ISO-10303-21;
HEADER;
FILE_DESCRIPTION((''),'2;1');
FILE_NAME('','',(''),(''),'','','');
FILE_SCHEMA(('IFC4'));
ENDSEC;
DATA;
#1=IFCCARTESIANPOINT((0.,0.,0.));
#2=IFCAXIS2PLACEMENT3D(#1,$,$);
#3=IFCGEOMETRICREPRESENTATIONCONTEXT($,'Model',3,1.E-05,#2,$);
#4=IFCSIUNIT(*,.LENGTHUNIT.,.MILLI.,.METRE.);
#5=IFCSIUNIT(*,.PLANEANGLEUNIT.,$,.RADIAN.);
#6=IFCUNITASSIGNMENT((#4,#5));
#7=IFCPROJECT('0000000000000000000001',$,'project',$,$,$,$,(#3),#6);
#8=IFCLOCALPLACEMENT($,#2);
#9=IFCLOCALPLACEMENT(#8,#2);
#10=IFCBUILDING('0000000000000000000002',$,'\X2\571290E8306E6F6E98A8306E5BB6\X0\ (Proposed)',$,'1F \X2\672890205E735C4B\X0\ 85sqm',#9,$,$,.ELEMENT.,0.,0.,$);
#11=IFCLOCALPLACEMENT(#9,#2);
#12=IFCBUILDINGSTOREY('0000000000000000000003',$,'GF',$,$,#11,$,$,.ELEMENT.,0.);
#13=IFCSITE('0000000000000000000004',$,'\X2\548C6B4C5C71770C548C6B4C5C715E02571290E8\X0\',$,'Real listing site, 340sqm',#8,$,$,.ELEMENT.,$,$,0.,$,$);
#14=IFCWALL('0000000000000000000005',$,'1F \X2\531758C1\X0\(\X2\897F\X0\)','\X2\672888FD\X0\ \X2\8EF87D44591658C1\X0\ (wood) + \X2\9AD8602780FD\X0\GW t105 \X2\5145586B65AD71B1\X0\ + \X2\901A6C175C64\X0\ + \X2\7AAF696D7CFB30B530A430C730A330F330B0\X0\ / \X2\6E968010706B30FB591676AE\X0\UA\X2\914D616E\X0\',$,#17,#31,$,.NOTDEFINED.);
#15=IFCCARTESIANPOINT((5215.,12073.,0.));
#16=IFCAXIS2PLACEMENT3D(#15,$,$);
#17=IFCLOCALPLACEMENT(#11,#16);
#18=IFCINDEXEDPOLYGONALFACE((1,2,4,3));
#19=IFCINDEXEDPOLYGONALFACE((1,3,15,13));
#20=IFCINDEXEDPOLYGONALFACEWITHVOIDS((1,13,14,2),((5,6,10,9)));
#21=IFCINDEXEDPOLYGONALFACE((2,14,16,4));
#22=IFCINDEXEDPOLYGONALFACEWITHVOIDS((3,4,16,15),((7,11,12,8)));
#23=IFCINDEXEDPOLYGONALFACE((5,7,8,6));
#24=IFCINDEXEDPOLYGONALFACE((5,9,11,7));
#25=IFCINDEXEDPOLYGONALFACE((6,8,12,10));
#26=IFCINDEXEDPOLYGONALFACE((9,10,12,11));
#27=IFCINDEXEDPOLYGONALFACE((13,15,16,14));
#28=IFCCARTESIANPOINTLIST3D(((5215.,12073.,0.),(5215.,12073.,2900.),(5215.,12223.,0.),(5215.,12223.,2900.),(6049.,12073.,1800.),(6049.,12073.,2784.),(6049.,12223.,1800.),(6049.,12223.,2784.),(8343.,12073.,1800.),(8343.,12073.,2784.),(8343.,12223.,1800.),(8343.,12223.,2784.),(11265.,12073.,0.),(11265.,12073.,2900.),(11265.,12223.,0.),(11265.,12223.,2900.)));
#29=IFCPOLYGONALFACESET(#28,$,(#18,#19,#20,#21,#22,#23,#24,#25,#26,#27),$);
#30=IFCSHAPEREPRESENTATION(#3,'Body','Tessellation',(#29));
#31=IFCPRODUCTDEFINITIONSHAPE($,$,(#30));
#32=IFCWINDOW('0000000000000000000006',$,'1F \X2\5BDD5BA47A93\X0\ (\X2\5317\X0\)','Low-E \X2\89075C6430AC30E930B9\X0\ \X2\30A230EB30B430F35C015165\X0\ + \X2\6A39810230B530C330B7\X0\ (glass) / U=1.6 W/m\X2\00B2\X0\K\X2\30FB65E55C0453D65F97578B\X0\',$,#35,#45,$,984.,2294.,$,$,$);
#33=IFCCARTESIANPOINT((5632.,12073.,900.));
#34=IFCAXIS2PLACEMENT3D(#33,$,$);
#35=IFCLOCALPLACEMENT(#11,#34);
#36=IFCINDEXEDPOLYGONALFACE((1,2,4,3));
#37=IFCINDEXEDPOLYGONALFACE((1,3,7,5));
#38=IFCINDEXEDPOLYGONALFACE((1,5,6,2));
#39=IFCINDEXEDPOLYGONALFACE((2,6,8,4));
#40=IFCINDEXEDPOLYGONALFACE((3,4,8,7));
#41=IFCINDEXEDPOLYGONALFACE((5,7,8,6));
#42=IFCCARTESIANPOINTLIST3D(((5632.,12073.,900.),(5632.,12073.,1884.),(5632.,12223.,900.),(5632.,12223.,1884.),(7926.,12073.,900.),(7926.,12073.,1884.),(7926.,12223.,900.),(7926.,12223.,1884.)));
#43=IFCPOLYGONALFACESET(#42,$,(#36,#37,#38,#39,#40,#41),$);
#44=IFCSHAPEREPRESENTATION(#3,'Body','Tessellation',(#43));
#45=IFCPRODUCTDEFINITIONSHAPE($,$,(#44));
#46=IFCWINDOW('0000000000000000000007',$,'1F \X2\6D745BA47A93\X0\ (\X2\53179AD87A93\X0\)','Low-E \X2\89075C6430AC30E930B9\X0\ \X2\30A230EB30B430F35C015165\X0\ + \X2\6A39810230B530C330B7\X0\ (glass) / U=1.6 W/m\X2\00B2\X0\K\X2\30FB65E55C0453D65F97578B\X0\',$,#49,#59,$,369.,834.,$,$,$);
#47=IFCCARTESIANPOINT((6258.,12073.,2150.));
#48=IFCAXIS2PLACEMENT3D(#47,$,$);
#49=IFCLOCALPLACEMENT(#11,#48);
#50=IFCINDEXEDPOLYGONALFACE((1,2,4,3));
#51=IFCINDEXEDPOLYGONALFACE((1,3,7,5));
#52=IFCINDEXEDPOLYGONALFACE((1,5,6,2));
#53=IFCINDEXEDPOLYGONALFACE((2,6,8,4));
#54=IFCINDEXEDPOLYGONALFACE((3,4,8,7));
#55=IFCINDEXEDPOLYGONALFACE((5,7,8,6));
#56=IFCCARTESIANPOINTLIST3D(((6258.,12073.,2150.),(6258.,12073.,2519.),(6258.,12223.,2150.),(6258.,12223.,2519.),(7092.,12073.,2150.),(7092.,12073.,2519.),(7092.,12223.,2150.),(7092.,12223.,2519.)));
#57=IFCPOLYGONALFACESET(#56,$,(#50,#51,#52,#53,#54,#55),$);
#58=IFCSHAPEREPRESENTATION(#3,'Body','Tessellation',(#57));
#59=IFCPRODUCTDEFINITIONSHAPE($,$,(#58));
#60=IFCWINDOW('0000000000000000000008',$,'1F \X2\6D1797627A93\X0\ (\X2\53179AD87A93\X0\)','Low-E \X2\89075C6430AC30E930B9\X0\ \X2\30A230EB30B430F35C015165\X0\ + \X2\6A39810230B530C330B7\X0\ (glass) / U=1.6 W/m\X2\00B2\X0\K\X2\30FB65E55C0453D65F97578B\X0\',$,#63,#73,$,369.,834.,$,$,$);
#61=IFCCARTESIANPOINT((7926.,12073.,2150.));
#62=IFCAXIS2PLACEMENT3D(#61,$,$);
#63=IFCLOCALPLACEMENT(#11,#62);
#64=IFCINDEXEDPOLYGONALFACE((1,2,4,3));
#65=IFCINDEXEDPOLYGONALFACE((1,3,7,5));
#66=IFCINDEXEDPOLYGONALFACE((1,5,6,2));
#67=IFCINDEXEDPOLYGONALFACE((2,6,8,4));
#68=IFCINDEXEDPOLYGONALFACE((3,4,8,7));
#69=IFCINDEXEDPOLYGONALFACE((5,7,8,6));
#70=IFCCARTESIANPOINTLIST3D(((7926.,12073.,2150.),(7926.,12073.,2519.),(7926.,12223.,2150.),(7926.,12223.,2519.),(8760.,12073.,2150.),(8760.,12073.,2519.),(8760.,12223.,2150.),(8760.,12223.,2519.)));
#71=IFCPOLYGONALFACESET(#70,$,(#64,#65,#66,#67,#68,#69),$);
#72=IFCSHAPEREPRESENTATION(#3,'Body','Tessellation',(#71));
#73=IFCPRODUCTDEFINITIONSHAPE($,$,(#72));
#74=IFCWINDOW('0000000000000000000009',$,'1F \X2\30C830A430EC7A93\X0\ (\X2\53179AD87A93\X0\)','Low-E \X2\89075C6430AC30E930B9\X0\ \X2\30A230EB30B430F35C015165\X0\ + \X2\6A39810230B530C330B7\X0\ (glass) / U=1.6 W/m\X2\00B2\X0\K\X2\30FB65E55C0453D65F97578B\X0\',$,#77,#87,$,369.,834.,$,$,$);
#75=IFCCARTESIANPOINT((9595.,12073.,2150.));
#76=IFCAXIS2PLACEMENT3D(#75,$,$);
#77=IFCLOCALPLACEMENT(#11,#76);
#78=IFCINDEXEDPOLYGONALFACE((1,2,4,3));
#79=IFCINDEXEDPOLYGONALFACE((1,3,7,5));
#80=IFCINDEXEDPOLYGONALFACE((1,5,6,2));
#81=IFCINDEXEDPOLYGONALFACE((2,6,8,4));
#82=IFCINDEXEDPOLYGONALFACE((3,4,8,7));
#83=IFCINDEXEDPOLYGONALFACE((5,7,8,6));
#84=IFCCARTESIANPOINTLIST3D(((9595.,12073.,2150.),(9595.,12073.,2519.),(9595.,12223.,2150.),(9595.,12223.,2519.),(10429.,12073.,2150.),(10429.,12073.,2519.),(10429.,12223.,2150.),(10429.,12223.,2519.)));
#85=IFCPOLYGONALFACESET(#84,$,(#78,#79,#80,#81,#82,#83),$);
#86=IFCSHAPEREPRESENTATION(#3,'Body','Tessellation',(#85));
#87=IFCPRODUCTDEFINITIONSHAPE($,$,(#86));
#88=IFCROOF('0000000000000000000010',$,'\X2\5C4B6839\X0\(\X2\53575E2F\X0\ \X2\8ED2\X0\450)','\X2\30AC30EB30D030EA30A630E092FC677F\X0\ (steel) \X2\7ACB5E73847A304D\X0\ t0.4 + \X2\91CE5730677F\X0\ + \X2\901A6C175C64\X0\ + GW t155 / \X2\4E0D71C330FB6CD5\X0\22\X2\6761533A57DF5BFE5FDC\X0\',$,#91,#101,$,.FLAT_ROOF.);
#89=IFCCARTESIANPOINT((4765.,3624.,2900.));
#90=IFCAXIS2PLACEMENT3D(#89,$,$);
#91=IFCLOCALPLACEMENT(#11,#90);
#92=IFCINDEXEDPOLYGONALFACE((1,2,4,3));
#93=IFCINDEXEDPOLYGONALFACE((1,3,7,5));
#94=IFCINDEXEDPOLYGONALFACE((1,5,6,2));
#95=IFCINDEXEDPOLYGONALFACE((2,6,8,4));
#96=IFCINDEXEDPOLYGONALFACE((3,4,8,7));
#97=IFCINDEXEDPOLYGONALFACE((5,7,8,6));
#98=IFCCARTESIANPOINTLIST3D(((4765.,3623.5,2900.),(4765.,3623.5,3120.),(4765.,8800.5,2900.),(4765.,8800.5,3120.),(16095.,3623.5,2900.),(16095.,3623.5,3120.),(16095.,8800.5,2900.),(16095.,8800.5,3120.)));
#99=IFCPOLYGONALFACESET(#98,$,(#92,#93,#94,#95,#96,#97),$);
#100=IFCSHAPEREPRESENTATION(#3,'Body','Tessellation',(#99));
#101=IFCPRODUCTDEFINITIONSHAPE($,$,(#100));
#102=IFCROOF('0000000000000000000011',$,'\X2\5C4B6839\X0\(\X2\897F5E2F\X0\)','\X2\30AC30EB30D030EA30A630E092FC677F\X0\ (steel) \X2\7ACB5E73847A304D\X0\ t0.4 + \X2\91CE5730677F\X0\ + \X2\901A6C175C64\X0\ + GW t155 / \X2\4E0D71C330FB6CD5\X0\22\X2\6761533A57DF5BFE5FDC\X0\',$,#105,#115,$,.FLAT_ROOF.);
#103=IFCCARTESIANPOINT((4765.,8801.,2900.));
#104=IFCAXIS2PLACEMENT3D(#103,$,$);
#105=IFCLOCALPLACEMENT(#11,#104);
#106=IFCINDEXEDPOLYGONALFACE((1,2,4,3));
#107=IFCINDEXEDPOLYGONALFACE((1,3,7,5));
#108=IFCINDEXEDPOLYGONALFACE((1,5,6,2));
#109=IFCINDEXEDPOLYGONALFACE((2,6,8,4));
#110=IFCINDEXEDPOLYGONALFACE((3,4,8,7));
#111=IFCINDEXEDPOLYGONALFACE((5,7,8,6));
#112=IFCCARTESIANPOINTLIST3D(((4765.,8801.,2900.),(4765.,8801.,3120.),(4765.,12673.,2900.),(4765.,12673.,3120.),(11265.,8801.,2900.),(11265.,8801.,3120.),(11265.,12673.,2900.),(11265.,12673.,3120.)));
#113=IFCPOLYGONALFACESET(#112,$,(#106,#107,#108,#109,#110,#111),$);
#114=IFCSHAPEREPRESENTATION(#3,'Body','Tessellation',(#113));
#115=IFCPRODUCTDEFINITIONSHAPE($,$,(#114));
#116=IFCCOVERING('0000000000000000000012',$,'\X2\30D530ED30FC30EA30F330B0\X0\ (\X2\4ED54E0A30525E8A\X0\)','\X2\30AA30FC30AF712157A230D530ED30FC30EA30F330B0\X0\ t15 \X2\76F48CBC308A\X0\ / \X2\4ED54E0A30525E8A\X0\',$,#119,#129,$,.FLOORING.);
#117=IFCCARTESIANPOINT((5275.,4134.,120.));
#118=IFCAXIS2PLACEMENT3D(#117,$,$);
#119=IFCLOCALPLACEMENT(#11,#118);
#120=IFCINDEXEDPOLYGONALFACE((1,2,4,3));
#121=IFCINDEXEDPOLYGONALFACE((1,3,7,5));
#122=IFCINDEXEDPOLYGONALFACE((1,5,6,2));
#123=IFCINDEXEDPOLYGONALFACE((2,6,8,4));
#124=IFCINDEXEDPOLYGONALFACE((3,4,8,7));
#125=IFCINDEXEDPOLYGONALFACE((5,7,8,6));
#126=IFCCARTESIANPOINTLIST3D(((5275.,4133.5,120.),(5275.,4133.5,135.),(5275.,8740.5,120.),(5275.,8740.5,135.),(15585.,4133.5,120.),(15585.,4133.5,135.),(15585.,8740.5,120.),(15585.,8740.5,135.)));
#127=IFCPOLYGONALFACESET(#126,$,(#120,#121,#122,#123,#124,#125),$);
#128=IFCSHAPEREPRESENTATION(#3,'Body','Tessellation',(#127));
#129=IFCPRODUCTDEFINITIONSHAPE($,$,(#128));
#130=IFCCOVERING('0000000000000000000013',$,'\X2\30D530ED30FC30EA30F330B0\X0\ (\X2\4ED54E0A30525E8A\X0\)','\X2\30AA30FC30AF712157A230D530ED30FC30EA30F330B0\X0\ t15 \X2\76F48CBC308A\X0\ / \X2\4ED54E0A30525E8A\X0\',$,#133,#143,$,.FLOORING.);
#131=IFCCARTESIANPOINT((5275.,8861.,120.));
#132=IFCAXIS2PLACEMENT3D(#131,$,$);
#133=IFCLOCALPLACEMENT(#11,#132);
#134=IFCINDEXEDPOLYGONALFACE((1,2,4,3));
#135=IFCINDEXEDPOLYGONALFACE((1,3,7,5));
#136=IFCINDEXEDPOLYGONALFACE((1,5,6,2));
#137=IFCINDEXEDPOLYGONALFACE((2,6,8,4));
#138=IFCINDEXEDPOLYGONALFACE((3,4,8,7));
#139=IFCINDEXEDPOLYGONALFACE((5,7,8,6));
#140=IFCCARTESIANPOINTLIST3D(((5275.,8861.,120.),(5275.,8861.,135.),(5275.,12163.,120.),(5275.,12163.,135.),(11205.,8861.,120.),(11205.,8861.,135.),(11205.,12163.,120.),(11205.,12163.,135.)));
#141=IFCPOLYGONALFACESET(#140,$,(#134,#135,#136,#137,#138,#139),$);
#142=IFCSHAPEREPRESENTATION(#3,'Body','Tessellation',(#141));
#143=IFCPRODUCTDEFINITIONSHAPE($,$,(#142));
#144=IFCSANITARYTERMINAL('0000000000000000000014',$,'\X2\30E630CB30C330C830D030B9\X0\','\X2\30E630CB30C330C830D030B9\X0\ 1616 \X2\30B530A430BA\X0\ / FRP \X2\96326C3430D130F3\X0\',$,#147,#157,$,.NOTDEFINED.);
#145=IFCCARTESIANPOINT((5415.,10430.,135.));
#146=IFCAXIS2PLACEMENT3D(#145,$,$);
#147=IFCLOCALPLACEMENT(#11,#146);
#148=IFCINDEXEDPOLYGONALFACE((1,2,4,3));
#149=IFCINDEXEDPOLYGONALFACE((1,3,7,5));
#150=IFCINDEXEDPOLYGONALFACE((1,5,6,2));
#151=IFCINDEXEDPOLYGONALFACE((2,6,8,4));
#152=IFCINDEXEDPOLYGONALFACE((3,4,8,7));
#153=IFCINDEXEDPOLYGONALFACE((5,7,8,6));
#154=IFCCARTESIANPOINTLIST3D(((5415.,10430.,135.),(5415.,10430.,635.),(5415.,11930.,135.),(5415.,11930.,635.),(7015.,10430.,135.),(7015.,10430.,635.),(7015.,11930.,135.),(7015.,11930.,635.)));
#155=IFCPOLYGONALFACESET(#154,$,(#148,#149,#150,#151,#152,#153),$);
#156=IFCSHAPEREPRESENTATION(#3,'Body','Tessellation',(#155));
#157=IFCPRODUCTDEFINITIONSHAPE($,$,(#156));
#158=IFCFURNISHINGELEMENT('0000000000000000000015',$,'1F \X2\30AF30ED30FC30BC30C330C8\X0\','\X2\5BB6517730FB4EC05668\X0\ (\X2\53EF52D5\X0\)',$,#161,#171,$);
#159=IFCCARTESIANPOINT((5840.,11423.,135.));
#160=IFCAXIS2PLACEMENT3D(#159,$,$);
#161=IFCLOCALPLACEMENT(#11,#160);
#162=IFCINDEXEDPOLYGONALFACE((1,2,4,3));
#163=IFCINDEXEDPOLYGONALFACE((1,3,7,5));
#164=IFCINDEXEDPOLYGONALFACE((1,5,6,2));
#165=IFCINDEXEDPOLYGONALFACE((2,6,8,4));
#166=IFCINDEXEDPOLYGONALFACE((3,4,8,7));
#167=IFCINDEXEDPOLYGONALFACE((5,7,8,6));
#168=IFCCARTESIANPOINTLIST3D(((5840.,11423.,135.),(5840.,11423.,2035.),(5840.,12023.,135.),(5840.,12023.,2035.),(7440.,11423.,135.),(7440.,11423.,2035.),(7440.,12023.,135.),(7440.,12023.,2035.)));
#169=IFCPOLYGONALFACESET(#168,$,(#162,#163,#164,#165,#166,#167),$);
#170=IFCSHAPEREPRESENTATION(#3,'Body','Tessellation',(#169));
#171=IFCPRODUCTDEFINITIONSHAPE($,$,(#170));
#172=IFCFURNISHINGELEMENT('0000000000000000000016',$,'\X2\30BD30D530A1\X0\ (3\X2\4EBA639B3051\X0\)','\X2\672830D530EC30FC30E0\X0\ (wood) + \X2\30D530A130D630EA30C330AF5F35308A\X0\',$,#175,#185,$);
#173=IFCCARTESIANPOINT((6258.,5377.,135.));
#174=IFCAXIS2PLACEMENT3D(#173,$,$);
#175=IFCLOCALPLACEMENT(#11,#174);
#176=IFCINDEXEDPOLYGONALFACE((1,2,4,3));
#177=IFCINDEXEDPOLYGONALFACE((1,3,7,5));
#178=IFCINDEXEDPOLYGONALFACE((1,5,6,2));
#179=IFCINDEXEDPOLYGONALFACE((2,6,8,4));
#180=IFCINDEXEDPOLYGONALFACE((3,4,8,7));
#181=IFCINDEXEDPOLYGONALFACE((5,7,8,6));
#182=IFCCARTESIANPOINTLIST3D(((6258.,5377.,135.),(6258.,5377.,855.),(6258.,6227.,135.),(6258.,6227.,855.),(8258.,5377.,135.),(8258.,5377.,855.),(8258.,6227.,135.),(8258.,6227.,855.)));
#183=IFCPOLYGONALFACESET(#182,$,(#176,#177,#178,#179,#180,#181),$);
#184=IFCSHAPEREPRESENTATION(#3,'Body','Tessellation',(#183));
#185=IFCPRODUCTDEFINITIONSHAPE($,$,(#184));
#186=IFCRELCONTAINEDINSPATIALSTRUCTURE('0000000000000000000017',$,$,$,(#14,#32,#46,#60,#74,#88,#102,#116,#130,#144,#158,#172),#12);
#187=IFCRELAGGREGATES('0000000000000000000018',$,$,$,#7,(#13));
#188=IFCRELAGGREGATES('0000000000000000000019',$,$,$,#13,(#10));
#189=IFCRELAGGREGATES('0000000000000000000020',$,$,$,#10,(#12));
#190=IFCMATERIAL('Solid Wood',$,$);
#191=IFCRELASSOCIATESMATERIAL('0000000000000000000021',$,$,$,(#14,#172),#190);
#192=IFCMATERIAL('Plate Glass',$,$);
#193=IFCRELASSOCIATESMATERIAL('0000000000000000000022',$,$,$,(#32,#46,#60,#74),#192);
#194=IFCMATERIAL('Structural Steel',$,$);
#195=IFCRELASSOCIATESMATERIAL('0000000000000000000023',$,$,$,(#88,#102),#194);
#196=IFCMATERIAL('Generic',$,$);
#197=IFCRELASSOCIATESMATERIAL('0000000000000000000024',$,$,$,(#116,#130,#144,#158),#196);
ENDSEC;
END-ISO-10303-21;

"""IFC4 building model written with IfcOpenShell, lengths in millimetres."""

from ifc_helpers import new_model, si_unit, frame, frame_2d, origin, place, context, project, spatial, rectangle, extrude, material, element, fill, save


model = new_model("IFC4")

# Units and contexts
model_context = context("Model", 3, precision=1e-05, world=origin())
ifc_project = project(units=[si_unit("LENGTHUNIT", "METRE", prefix="MILLI"), si_unit("PLANEANGLEUNIT", "RADIAN")], contexts=[model_context])

# Site, building, storey
site_placement = place(None, origin())
site = spatial("IfcSite", under=ifc_project, at=site_placement, Name="和歌山県和歌山市園部", ObjectType="Real listing site, 340sqm", CompositionType="ELEMENT", RefElevation=0.0)
building_placement = place(site_placement, origin())
building = spatial("IfcBuilding", under=site, at=building_placement, Name="園部の潮風の家 (Proposed)", ObjectType="1F 木造平屋 85sqm", CompositionType="ELEMENT", ElevationOfRefHeight=0.0, ElevationOfTerrain=0.0)
storey_placement = place(building_placement, origin())
storey = spatial("IfcBuildingStorey", under=building, at=storey_placement, Name="GF", CompositionType="ELEMENT", Elevation=0.0)

# Shared definitions
ifc_material_1 = material(Name="Solid Wood")

# Shared definitions
ifc_material_2 = material(Name="Plate Glass")

# Wall, openings, windows
wall_1_placement = place(storey_placement, frame((5215.0, 12073.0, 0.0)))
wall_1 = element("IfcWall", 1, at=wall_1_placement, inside=storey, material=ifc_material_1, Name="1F 北壁(西)", Description="木製 軸組外壁 (wood) + 高性能GW t105 充填断熱 + 通気層 + 窯業系サイディング / 準耐火・外皮UA配慮", PredefinedType="NOTDEFINED", context=model_context, shape_type="SweptSolid", body=[
    extrude(rectangle(XDim=6050.0, YDim=150.0, at=frame_2d((3025.0, 75.0))), frame((5215.0, 12073.0, 0.0)), (0.0, 0.0, 1.0), 2900.0),
])
opening_1_placement = place(storey_placement, frame((5632.0, 12073.0, 900.0)))
opening_1 = element("IfcOpeningElement", 2, at=opening_1_placement, cuts=wall_1, PredefinedType="NOTDEFINED", context=model_context, shape_type="SweptSolid", body=[
    extrude(rectangle(XDim=2294.0, YDim=150.0, at=frame_2d((1147.0, 75.0))), frame((5632.0, 12073.0, 900.0)), (0.0, 0.0, 1.0), 984.0),
])
opening_2_placement = place(storey_placement, frame((6258.0, 12073.0, 2150.0)))
opening_2 = element("IfcOpeningElement", 3, at=opening_2_placement, cuts=wall_1, PredefinedType="NOTDEFINED", context=model_context, shape_type="SweptSolid", body=[
    extrude(rectangle(XDim=834.0, YDim=150.0, at=frame_2d((417.0, 75.0))), frame((6258.0, 12073.0, 2150.0)), (0.0, 0.0, 1.0), 369.0),
])
opening_3_placement = place(storey_placement, frame((7926.0, 12073.0, 2150.0)))
opening_3 = element("IfcOpeningElement", 4, at=opening_3_placement, cuts=wall_1, PredefinedType="NOTDEFINED", context=model_context, shape_type="SweptSolid", body=[
    extrude(rectangle(XDim=834.0, YDim=150.0, at=frame_2d((417.0, 75.0))), frame((7926.0, 12073.0, 2150.0)), (0.0, 0.0, 1.0), 369.0),
])
opening_4_placement = place(storey_placement, frame((9595.0, 12073.0, 2150.0)))
opening_4 = element("IfcOpeningElement", 5, at=opening_4_placement, cuts=wall_1, PredefinedType="NOTDEFINED", context=model_context, shape_type="SweptSolid", body=[
    extrude(rectangle(XDim=834.0, YDim=150.0, at=frame_2d((417.0, 75.0))), frame((9595.0, 12073.0, 2150.0)), (0.0, 0.0, 1.0), 369.0),
])
window_1_placement = place(storey_placement, frame((5632.0, 12073.0, 900.0)))
window_1 = element("IfcWindow", 6, at=window_1_placement, inside=storey, material=ifc_material_2, Name="1F 寝室窓 (北)", Description="Low-E 複層ガラス アルゴン封入 + 樹脂サッシ (glass) / U=1.6 W/m²K・日射取得型", OverallHeight=984.0, OverallWidth=2294.0, context=model_context, shape_type="SweptSolid", body=[
    extrude(rectangle(XDim=2294.0, YDim=150.0, at=frame_2d((1147.0, 75.0))), frame((5632.0, 12073.0, 900.0)), (0.0, 0.0, 1.0), 984.0),
])
fill(opening_1, window_1)
window_2_placement = place(storey_placement, frame((6258.0, 12073.0, 2150.0)))
window_2 = element("IfcWindow", 7, at=window_2_placement, inside=storey, material=ifc_material_2, Name="1F 浴室窓 (北高窓)", Description="Low-E 複層ガラス アルゴン封入 + 樹脂サッシ (glass) / U=1.6 W/m²K・日射取得型", OverallHeight=369.0, OverallWidth=834.0, context=model_context, shape_type="SweptSolid", body=[
    extrude(rectangle(XDim=834.0, YDim=150.0, at=frame_2d((417.0, 75.0))), frame((6258.0, 12073.0, 2150.0)), (0.0, 0.0, 1.0), 369.0),
])
fill(opening_2, window_2)
window_3_placement = place(storey_placement, frame((7926.0, 12073.0, 2150.0)))
window_3 = element("IfcWindow", 8, at=window_3_placement, inside=storey, material=ifc_material_2, Name="1F 洗面窓 (北高窓)", Description="Low-E 複層ガラス アルゴン封入 + 樹脂サッシ (glass) / U=1.6 W/m²K・日射取得型", OverallHeight=369.0, OverallWidth=834.0, context=model_context, shape_type="SweptSolid", body=[
    extrude(rectangle(XDim=834.0, YDim=150.0, at=frame_2d((417.0, 75.0))), frame((7926.0, 12073.0, 2150.0)), (0.0, 0.0, 1.0), 369.0),
])
fill(opening_3, window_3)
window_4_placement = place(storey_placement, frame((9595.0, 12073.0, 2150.0)))
window_4 = element("IfcWindow", 9, at=window_4_placement, inside=storey, material=ifc_material_2, Name="1F トイレ窓 (北高窓)", Description="Low-E 複層ガラス アルゴン封入 + 樹脂サッシ (glass) / U=1.6 W/m²K・日射取得型", OverallHeight=369.0, OverallWidth=834.0, context=model_context, shape_type="SweptSolid", body=[
    extrude(rectangle(XDim=834.0, YDim=150.0, at=frame_2d((417.0, 75.0))), frame((9595.0, 12073.0, 2150.0)), (0.0, 0.0, 1.0), 369.0),
])
fill(opening_4, window_4)

# Roofs
ifc_material_3 = material(Name="Structural Steel")
roof_1_placement = place(storey_placement, frame((4765.0, 3624.0, 2900.0)))
element("IfcRoof", 10, at=roof_1_placement, inside=storey, material=ifc_material_3, Name="屋根(南帯 軒450)", Description="ガルバリウム鋼板 (steel) 立平葺き t0.4 + 野地板 + 通気層 + GW t155 / 不燃・法22条区域対応", PredefinedType="FLAT_ROOF", context=model_context, shape_type="SweptSolid", body=[
    extrude(rectangle(XDim=11330.0, YDim=5177.0, at=frame_2d((5665.0, 2588.0))), frame((4765.0, 3624.0, 2900.0)), (0.0, 0.0, 1.0), 220.0),
])
roof_2_placement = place(storey_placement, frame((4765.0, 8801.0, 2900.0)))
element("IfcRoof", 11, at=roof_2_placement, inside=storey, material=ifc_material_3, Name="屋根(西帯)", Description="ガルバリウム鋼板 (steel) 立平葺き t0.4 + 野地板 + 通気層 + GW t155 / 不燃・法22条区域対応", PredefinedType="FLAT_ROOF", context=model_context, shape_type="SweptSolid", body=[
    extrude(rectangle(XDim=6500.0, YDim=3872.0, at=frame_2d((3250.0, 1936.0))), frame((4765.0, 8801.0, 2900.0)), (0.0, 0.0, 1.0), 220.0),
])

# Coverings
ifc_material_4 = material(Name="Generic")
covering_1_placement = place(storey_placement, frame((5275.0, 4134.0, 120.0)))
element("IfcCovering", 12, at=covering_1_placement, inside=storey, material=ifc_material_4, Name="フローリング (仕上げ床)", Description="オーク無垢フローリング t15 直貼り / 仕上げ床", PredefinedType="FLOORING", context=model_context, shape_type="SweptSolid", body=[
    extrude(rectangle(XDim=10310.0, YDim=4607.0, at=frame_2d((5155.0, 2303.0))), frame((5275.0, 4134.0, 120.0)), (0.0, 0.0, 1.0), 15.0),
])
covering_2_placement = place(storey_placement, frame((5275.0, 8861.0, 120.0)))
element("IfcCovering", 13, at=covering_2_placement, inside=storey, material=ifc_material_4, Name="フローリング (仕上げ床)", Description="オーク無垢フローリング t15 直貼り / 仕上げ床", PredefinedType="FLOORING", context=model_context, shape_type="SweptSolid", body=[
    extrude(rectangle(XDim=5930.0, YDim=3302.0, at=frame_2d((2965.0, 1651.0))), frame((5275.0, 8861.0, 120.0)), (0.0, 0.0, 1.0), 15.0),
])

# Sanitary terminal
sanitary_terminal_placement = place(storey_placement, frame((5415.0, 10430.0, 135.0)))
element("IfcSanitaryTerminal", 14, at=sanitary_terminal_placement, inside=storey, material=ifc_material_4, Name="ユニットバス", Description="ユニットバス 1616 サイズ / FRP 防水パン", PredefinedType="NOTDEFINED", context=model_context, shape_type="SweptSolid", body=[
    extrude(rectangle(XDim=1600.0, YDim=1500.0, at=frame_2d((800.0, 750.0))), frame((5415.0, 10430.0, 135.0)), (0.0, 0.0, 1.0), 500.0),
])

# Furnishing elements
furnishing_1_placement = place(storey_placement, frame((5840.0, 11423.0, 135.0)))
element("IfcFurnishingElement", 15, at=furnishing_1_placement, inside=storey, material=ifc_material_4, Name="1F クローゼット", Description="家具・什器 (可動)", context=model_context, shape_type="SweptSolid", body=[
    extrude(rectangle(XDim=1600.0, YDim=600.0, at=frame_2d((800.0, 300.0))), frame((5840.0, 11423.0, 135.0)), (0.0, 0.0, 1.0), 1900.0),
])
furnishing_2_placement = place(storey_placement, frame((6258.0, 5377.0, 135.0)))
element("IfcFurnishingElement", 16, at=furnishing_2_placement, inside=storey, material=ifc_material_1, Name="ソファ (3人掛け)", Description="木フレーム (wood) + ファブリック張り", context=model_context, shape_type="SweptSolid", body=[
    extrude(rectangle(XDim=2000.0, YDim=850.0, at=frame_2d((1000.0, 425.0))), frame((6258.0, 5377.0, 135.0)), (0.0, 0.0, 1.0), 720.0),
])

save(model, "model.ifc")
